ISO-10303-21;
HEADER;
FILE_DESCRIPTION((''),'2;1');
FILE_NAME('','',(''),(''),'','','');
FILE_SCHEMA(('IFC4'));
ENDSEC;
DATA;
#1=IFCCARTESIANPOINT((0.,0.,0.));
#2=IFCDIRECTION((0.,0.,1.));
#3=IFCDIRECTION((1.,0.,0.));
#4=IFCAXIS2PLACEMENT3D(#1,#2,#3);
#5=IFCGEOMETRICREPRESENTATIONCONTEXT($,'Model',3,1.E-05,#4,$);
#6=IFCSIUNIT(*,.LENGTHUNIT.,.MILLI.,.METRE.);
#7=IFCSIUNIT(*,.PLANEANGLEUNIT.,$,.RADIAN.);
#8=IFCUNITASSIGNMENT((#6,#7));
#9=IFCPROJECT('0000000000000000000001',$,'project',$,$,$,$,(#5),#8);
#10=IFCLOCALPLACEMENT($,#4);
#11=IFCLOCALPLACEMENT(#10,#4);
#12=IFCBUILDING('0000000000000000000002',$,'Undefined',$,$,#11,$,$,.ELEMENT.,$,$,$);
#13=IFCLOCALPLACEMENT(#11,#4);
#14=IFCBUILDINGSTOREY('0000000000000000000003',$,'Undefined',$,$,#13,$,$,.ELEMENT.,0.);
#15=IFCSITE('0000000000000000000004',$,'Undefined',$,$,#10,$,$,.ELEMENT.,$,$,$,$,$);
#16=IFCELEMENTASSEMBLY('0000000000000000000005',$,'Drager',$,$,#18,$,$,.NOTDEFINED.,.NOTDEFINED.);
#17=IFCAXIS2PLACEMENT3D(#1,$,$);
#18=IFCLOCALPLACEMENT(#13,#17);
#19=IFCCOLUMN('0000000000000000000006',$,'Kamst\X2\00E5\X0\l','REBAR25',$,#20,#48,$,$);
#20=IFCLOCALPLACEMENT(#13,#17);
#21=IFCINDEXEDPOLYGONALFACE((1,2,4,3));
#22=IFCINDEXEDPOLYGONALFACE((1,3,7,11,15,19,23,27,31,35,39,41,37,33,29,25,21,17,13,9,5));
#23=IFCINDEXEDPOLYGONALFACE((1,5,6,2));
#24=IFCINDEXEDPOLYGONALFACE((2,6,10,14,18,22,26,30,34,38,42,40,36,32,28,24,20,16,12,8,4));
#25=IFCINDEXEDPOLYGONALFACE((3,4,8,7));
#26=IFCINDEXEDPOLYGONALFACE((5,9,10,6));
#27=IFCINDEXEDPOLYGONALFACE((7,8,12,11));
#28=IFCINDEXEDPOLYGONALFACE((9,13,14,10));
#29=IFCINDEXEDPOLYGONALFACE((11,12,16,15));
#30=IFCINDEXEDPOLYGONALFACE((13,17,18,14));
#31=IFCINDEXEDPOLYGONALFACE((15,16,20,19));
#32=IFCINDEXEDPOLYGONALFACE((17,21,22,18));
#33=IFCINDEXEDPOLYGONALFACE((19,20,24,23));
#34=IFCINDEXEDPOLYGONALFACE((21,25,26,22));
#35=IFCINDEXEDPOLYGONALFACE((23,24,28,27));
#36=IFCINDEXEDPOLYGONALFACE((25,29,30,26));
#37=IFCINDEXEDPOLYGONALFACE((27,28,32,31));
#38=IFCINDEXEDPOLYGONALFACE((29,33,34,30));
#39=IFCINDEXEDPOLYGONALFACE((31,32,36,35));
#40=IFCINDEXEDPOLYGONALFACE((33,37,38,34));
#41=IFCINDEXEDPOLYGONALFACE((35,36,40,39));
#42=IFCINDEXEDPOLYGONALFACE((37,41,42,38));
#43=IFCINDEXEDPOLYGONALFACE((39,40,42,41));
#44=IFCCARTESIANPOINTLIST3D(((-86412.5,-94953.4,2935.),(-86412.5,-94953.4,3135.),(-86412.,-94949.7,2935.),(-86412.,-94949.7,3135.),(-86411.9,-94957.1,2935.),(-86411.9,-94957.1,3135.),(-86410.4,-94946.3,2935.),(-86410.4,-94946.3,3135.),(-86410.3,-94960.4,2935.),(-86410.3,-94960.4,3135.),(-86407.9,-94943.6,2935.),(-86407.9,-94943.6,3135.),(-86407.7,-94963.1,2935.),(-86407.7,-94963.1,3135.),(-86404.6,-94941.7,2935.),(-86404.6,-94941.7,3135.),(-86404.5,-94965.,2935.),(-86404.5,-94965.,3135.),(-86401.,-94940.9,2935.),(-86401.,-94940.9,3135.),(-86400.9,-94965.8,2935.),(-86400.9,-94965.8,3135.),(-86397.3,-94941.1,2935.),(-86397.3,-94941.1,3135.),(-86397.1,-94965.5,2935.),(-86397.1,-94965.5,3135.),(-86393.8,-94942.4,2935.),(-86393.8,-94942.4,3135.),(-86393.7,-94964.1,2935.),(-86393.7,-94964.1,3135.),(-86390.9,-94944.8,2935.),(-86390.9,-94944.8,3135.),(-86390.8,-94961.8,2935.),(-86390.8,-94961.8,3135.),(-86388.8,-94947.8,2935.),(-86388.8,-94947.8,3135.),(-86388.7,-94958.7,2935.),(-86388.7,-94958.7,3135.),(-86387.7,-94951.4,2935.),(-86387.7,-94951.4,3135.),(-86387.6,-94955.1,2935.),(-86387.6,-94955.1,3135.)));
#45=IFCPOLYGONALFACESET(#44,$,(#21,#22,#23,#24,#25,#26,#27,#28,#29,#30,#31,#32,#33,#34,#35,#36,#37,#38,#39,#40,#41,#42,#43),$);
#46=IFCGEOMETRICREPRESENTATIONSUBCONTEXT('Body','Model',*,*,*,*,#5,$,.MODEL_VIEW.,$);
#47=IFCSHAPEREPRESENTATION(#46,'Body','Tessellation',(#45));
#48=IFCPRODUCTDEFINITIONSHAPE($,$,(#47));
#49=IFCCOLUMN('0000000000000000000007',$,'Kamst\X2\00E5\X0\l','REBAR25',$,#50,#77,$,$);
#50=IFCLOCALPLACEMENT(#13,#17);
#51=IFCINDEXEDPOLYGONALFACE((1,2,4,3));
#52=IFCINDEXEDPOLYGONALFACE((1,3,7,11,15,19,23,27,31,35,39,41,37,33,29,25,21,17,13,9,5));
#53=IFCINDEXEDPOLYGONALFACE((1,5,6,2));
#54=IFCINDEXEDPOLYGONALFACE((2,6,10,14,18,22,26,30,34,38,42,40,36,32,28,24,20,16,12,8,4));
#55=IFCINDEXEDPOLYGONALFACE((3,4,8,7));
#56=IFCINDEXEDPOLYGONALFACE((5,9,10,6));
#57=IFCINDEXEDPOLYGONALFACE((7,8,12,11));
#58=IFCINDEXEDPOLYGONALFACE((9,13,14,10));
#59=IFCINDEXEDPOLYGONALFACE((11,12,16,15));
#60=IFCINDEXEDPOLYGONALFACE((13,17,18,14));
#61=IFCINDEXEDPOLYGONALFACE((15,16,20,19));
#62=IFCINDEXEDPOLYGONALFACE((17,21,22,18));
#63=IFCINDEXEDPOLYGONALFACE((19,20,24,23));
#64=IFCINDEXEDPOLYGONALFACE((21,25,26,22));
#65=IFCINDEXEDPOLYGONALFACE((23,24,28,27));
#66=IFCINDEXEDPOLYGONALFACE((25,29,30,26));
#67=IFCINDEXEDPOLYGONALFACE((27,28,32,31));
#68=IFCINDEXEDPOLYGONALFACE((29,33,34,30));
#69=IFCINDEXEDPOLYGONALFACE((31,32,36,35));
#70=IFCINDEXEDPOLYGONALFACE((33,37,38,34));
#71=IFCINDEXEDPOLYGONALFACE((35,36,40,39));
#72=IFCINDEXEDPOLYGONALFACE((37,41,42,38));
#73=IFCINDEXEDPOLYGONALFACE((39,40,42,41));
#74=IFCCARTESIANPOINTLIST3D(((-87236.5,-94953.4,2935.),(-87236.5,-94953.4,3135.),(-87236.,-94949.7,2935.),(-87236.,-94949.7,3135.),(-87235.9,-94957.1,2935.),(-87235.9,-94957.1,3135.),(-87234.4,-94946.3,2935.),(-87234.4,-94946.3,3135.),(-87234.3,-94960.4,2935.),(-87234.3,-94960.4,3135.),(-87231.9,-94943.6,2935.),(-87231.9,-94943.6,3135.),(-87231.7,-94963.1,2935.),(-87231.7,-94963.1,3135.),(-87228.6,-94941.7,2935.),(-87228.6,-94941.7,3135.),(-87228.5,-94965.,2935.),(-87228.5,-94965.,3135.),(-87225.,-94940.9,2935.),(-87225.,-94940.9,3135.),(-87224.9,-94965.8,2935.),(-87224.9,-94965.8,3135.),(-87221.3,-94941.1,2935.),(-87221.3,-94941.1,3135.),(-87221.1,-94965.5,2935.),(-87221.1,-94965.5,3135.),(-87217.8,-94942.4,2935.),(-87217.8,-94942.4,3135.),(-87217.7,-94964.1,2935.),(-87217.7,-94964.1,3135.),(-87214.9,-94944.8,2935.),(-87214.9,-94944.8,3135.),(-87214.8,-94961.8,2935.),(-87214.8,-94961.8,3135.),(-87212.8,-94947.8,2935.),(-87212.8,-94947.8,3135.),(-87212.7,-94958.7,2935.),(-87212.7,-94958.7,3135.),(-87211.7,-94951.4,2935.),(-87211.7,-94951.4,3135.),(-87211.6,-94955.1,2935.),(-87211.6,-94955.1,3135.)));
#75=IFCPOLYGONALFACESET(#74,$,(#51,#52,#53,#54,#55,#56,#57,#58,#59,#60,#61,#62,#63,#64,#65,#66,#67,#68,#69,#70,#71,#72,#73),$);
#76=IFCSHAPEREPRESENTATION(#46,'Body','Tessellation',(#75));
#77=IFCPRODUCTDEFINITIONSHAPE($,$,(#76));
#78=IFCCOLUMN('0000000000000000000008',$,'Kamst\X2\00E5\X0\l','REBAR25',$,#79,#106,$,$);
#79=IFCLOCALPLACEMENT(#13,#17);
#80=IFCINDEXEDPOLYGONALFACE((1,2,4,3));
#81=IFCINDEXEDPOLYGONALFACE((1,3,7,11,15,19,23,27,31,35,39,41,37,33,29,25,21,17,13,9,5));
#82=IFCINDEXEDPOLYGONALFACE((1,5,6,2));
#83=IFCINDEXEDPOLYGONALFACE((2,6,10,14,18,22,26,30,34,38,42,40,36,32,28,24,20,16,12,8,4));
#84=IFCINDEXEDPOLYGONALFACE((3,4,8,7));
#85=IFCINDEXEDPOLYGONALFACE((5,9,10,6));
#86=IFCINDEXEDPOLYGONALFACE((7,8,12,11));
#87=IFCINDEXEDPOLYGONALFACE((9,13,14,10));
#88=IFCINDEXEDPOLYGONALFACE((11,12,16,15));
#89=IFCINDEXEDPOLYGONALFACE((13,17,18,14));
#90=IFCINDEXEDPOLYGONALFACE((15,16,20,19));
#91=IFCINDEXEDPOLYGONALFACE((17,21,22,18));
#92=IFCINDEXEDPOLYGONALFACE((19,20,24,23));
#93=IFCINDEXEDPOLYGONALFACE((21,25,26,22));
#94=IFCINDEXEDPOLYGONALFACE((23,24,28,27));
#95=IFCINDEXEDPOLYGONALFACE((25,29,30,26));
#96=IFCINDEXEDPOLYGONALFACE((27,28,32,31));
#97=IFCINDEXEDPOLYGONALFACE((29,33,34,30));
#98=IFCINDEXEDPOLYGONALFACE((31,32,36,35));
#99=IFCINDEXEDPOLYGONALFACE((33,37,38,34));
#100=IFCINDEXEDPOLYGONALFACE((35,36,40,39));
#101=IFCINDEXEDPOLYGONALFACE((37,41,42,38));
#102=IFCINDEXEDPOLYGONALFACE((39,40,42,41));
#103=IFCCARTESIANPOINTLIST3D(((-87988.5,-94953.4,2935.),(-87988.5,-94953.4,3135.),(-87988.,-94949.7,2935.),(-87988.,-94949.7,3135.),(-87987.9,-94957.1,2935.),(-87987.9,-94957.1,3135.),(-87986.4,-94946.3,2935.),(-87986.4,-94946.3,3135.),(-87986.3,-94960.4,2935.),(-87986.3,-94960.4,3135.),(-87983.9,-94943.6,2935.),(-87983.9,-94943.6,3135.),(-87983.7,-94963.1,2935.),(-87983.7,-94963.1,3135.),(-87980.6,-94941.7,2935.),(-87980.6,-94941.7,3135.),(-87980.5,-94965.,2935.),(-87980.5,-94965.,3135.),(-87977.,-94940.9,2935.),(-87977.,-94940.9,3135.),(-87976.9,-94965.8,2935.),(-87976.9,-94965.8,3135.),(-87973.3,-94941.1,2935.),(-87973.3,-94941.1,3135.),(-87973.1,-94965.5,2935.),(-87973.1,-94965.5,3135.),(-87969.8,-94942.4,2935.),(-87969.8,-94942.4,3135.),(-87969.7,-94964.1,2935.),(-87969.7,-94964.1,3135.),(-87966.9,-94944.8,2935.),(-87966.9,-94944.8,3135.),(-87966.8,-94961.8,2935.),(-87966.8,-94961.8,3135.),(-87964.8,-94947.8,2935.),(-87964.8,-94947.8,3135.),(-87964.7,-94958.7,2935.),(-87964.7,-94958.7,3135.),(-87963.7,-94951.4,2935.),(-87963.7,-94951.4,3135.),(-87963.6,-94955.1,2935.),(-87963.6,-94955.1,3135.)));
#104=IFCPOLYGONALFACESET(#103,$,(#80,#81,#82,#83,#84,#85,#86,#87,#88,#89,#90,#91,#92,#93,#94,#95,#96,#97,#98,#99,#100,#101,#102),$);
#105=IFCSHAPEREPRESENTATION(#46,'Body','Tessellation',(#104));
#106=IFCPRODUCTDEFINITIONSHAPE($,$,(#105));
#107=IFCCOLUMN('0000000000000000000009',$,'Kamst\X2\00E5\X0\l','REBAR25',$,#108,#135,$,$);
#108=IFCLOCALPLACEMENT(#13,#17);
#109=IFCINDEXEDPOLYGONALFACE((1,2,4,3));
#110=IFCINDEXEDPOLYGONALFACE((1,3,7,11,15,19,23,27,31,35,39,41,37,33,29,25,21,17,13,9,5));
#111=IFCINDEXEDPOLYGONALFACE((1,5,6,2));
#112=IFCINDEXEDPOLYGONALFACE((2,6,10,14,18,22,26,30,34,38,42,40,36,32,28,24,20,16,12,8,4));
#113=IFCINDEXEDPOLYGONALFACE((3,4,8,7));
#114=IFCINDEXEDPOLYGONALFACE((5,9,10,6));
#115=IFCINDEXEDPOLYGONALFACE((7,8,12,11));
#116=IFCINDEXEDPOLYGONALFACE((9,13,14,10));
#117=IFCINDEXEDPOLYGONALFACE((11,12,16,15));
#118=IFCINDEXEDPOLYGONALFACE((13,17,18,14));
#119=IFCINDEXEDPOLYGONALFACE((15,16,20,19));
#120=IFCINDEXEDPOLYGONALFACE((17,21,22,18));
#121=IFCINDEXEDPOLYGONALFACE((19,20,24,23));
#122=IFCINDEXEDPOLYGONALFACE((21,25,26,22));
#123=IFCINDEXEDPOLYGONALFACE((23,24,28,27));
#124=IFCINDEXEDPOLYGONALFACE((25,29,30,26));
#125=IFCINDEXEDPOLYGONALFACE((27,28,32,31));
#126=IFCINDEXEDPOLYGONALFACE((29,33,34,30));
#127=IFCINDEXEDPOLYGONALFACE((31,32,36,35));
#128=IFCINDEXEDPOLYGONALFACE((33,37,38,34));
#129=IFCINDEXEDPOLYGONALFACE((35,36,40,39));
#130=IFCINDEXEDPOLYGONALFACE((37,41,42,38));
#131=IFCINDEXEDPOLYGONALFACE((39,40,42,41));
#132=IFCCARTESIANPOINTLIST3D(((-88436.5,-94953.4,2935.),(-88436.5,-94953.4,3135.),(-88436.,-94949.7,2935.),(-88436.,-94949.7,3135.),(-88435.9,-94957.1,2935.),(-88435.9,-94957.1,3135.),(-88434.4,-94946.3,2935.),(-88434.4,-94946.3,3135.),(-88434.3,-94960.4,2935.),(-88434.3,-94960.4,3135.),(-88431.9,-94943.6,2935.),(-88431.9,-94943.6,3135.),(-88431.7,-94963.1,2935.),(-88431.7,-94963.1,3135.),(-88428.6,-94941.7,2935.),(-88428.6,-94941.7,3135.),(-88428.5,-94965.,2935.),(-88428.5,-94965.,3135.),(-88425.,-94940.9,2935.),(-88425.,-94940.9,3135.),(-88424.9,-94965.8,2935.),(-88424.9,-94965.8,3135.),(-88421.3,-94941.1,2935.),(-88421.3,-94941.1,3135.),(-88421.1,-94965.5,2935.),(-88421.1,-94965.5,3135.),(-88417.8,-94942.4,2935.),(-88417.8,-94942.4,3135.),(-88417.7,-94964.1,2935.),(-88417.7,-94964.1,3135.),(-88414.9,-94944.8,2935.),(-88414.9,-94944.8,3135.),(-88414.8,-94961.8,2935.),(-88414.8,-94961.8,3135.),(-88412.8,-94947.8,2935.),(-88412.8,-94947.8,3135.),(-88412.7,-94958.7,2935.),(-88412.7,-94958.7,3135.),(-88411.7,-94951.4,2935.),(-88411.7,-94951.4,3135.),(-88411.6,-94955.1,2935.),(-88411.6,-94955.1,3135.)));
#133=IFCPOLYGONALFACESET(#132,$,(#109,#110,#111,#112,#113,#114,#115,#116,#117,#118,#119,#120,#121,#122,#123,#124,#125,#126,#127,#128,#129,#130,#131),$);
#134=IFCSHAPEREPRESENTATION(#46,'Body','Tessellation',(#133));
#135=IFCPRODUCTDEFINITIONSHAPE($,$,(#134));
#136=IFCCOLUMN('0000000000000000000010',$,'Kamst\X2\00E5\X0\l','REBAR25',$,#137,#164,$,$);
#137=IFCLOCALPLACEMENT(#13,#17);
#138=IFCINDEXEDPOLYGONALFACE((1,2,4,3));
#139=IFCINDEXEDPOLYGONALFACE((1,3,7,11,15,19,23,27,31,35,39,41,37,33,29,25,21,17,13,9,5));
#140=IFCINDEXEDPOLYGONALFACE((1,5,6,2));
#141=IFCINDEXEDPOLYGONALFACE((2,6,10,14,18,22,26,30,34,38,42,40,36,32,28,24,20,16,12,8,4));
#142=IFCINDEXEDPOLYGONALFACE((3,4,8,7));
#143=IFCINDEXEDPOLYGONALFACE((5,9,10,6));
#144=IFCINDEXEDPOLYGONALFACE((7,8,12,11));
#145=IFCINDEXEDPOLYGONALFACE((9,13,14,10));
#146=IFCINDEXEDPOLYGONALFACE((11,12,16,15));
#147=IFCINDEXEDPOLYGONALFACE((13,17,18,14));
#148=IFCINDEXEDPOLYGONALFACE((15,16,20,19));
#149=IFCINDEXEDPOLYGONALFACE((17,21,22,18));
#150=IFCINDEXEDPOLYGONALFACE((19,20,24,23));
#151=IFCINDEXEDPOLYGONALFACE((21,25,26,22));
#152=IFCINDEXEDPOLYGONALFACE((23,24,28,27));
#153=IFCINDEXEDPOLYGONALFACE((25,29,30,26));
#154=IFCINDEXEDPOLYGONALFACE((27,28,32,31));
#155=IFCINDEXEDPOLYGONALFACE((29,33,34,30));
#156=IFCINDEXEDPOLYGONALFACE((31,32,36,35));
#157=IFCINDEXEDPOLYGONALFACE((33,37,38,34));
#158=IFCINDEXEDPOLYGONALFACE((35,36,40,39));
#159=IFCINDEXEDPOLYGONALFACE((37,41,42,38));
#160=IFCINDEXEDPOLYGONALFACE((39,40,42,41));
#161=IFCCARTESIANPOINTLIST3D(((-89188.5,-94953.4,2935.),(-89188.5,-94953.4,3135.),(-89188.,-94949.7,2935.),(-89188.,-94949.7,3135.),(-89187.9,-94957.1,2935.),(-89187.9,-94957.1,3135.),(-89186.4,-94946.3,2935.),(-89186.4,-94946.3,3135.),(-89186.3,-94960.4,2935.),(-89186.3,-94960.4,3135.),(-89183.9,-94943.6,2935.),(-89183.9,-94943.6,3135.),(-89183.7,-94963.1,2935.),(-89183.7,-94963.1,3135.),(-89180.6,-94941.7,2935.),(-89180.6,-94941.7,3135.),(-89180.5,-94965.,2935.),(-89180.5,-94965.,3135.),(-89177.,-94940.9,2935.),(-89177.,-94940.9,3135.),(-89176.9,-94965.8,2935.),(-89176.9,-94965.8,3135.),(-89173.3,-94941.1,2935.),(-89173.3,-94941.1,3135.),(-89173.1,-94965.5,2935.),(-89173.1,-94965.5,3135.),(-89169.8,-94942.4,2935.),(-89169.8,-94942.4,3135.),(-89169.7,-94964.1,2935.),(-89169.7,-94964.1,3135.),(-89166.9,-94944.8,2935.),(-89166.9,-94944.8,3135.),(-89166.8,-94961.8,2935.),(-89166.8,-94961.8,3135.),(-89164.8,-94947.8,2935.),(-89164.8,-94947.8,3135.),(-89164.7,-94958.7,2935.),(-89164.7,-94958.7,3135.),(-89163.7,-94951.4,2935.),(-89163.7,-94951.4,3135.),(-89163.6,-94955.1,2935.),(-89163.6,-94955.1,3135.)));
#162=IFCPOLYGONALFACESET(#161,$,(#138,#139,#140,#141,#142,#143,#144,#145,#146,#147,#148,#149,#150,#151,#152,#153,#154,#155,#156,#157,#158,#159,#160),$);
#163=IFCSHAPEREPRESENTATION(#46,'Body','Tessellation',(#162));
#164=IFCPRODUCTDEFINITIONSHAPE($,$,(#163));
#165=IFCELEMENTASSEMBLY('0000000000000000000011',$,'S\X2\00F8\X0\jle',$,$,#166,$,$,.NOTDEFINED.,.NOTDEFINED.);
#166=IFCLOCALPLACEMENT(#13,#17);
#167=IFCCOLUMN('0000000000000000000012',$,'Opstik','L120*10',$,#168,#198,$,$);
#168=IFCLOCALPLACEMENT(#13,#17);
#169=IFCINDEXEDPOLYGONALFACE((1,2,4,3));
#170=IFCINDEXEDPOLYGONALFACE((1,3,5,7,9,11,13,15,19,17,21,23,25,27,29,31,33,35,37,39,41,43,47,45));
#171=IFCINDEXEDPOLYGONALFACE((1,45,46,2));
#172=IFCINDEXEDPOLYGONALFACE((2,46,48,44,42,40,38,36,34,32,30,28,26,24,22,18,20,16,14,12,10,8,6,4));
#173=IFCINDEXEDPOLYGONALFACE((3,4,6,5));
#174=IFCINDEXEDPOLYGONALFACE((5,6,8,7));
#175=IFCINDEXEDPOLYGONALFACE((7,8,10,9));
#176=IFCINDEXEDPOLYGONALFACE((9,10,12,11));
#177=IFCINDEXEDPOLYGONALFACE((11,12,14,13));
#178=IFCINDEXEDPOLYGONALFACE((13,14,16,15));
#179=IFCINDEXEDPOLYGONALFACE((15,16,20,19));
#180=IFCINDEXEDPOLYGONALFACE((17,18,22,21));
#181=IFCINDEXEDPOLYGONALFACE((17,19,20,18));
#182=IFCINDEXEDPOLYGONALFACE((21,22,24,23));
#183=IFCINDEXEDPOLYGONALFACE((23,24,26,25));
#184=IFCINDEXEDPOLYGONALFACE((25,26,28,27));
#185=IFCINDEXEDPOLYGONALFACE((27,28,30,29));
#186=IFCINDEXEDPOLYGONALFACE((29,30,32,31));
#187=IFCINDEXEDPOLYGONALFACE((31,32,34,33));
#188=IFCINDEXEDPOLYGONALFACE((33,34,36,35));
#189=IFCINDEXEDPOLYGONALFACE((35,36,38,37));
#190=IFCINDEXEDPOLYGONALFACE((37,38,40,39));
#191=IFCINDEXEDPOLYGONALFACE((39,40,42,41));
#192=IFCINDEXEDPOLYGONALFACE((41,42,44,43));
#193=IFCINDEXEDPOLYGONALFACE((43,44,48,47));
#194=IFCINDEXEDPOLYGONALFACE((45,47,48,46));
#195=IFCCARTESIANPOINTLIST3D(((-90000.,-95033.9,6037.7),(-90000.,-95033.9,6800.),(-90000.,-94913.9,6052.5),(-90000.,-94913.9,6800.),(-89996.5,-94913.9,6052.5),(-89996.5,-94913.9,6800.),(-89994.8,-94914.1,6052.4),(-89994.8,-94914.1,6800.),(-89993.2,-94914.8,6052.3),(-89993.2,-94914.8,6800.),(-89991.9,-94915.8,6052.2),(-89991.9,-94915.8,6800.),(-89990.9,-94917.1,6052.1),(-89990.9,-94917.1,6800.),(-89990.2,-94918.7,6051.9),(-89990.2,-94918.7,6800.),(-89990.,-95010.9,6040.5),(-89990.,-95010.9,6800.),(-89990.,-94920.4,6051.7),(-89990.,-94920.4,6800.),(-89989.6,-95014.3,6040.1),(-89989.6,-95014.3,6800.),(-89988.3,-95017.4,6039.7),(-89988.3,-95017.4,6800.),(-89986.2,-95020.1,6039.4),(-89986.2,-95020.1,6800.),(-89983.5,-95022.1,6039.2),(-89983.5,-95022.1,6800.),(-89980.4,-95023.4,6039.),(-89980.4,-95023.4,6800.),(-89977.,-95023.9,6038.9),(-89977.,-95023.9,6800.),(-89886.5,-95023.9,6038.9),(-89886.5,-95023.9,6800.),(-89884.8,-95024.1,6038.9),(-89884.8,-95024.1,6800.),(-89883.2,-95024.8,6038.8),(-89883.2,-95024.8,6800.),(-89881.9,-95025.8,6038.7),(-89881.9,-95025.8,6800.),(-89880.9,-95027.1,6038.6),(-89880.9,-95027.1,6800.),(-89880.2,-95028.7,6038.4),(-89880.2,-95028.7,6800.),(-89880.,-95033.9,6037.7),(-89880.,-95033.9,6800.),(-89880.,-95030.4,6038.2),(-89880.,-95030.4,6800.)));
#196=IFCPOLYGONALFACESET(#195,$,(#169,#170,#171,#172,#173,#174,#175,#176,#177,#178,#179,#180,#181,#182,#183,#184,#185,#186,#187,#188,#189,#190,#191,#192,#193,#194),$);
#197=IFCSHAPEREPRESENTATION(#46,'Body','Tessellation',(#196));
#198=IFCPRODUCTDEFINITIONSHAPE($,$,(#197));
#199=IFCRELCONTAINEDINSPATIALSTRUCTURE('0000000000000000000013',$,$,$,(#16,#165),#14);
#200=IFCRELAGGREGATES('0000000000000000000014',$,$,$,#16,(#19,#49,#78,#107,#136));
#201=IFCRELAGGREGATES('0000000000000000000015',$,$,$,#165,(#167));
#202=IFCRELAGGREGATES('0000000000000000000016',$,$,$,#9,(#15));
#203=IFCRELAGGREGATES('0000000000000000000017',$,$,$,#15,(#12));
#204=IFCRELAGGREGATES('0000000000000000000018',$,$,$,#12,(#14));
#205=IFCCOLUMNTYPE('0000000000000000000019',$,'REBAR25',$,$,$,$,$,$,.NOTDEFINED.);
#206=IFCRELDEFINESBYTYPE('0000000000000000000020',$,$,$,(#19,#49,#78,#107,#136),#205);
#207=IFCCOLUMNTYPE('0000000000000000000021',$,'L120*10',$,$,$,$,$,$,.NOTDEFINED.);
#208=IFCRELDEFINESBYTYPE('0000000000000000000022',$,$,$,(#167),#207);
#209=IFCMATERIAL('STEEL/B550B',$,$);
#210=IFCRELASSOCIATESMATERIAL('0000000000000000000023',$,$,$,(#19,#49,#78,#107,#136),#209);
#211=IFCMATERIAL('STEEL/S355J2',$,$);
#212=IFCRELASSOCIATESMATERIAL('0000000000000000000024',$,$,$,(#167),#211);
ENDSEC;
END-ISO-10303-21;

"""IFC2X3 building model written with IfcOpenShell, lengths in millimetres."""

from ifc_helpers import new_model, si_unit, frame, origin_with_axes, origin_2d_with_axis, place, context, subcontext, project, spatial, circle, l_section, extrude, clip, halfspace, material, type_object, element, aggregate, save


model = new_model("IFC2X3")

# Units and contexts
model_context = context("Model", 3, precision=1e-05, world=origin_with_axes())
body_context = subcontext(model_context, "Body", "Model", "MODEL_VIEW")
ifc_project = project(units=[si_unit("LENGTHUNIT", "METRE", prefix="MILLI"), si_unit("PLANEANGLEUNIT", "RADIAN")], contexts=[model_context])

# Site, building, storey
site_placement = place(None, origin_with_axes())
site = spatial("IfcSite", under=ifc_project, at=site_placement, Name="Undefined", CompositionType="ELEMENT")
building_placement = place(site_placement, origin_with_axes())
building = spatial("IfcBuilding", under=site, at=building_placement, Name="Undefined", CompositionType="ELEMENT")
storey_placement = place(building_placement, origin_with_axes())
storey = spatial("IfcBuildingStorey", under=building, at=storey_placement, Name="Undefined", CompositionType="ELEMENT", Elevation=0.0)

# Element assembly, columns
assembly_1_placement = place(storey_placement, origin_with_axes())
assembly_1 = element("IfcElementAssembly", 1, at=assembly_1_placement, inside=storey, Name="Drager", AssemblyPlace="NOTDEFINED", PredefinedType="NOTDEFINED")
ifc_material_1 = material(Name="STEEL/B550B")
column_type_1 = type_object("IfcColumnType", Name="REBAR25", PredefinedType="NOTDEFINED")
column_1_placement = place(assembly_1_placement, frame((-86400.0, -94953.3, 2935.0), z_axis=(0.0, 0.0, 1.0), x_axis=(-0.862746, -0.505638, 0.0)))
column_1 = element("IfcColumn", 2, at=column_1_placement, type_object=column_type_1, material=ifc_material_1, Name="Kamstål", Description="REBAR25", context=body_context, shape_type="SweptSolid", body=[
    extrude(circle(Radius=12.5, at=origin_2d_with_axis()), frame((0.0, 0.0, 200.0), z_axis=(0.0, 0.0, -1.0), x_axis=(0.0, 1.0, 0.0)), (0.0, 0.0, 1.0), 200.0),
])
column_2_placement = place(assembly_1_placement, frame((-87224.0, -94953.3, 2935.0), z_axis=(0.0, 0.0, 1.0), x_axis=(-0.862746, -0.505638, 0.0)))
column_2 = element("IfcColumn", 3, at=column_2_placement, type_object=column_type_1, material=ifc_material_1, Name="Kamstål", Description="REBAR25", context=body_context, shape_type="SweptSolid", body=[
    extrude(circle(Radius=12.5, at=origin_2d_with_axis()), frame((0.0, 0.0, 200.0), z_axis=(0.0, 0.0, -1.0), x_axis=(0.0, 1.0, 0.0)), (0.0, 0.0, 1.0), 200.0),
])
column_3_placement = place(assembly_1_placement, frame((-87976.0, -94953.3, 2935.0), z_axis=(0.0, 0.0, 1.0), x_axis=(-0.862746, -0.505638, 0.0)))
column_3 = element("IfcColumn", 4, at=column_3_placement, type_object=column_type_1, material=ifc_material_1, Name="Kamstål", Description="REBAR25", context=body_context, shape_type="SweptSolid", body=[
    extrude(circle(Radius=12.5, at=origin_2d_with_axis()), frame((0.0, 0.0, 200.0), z_axis=(0.0, 0.0, -1.0), x_axis=(0.0, 1.0, 0.0)), (0.0, 0.0, 1.0), 200.0),
])
column_4_placement = place(assembly_1_placement, frame((-88424.0, -94953.3, 2935.0), z_axis=(0.0, 0.0, 1.0), x_axis=(-0.862746, -0.505638, 0.0)))
column_4 = element("IfcColumn", 5, at=column_4_placement, type_object=column_type_1, material=ifc_material_1, Name="Kamstål", Description="REBAR25", context=body_context, shape_type="SweptSolid", body=[
    extrude(circle(Radius=12.5, at=origin_2d_with_axis()), frame((0.0, 0.0, 200.0), z_axis=(0.0, 0.0, -1.0), x_axis=(0.0, 1.0, 0.0)), (0.0, 0.0, 1.0), 200.0),
])
column_5_placement = place(assembly_1_placement, frame((-89176.0, -94953.3, 2935.0), z_axis=(0.0, 0.0, 1.0), x_axis=(-0.862746, -0.505638, 0.0)))
column_5 = element("IfcColumn", 6, at=column_5_placement, type_object=column_type_1, material=ifc_material_1, Name="Kamstål", Description="REBAR25", context=body_context, shape_type="SweptSolid", body=[
    extrude(circle(Radius=12.5, at=origin_2d_with_axis()), frame((0.0, 0.0, 200.0), z_axis=(0.0, 0.0, -1.0), x_axis=(0.0, 1.0, 0.0)), (0.0, 0.0, 1.0), 200.0),
])

# Element assembly, column
assembly_2_placement = place(storey_placement, origin_with_axes())
assembly_2 = element("IfcElementAssembly", 7, at=assembly_2_placement, inside=storey, Name="Søjle", AssemblyPlace="NOTDEFINED", PredefinedType="NOTDEFINED")
ifc_material_2 = material(Name="STEEL/S355J2")
column_type_2 = type_object("IfcColumnType", Name="L120*10", PredefinedType="NOTDEFINED")
column_6_placement = place(assembly_2_placement, frame((-89940.0, -94973.9, 6000.0), z_axis=(0.0, 0.0, 1.0), x_axis=(1.0, 0.0, 0.0)))
column_6 = element("IfcColumn", 8, at=column_6_placement, type_object=column_type_2, material=ifc_material_2, Name="Opstik", Description="L120*10", context=body_context, shape_type="Clipping", body=[
    clip(extrude(l_section(Depth=120.0, Width=120.0, Thickness=10.0, FilletRadius=13.0, EdgeRadius=6.5, at=origin_2d_with_axis()), frame((0.0, 0.0, 800.0), z_axis=(0.0, 0.0, -1.0), x_axis=(0.0, 1.0, 0.0)), (0.0, 0.0, 1.0), 800.0), halfspace(frame((-60.0, -60.0, 37.7), z_axis=(0.0, 0.121872, -0.992546), x_axis=(1.0, 0.0, 0.0)), False)),
])

aggregate(assembly_1, [column_1, column_2, column_3, column_4, column_5])

aggregate(assembly_2, [column_6])

save(model, "model.ifc")
